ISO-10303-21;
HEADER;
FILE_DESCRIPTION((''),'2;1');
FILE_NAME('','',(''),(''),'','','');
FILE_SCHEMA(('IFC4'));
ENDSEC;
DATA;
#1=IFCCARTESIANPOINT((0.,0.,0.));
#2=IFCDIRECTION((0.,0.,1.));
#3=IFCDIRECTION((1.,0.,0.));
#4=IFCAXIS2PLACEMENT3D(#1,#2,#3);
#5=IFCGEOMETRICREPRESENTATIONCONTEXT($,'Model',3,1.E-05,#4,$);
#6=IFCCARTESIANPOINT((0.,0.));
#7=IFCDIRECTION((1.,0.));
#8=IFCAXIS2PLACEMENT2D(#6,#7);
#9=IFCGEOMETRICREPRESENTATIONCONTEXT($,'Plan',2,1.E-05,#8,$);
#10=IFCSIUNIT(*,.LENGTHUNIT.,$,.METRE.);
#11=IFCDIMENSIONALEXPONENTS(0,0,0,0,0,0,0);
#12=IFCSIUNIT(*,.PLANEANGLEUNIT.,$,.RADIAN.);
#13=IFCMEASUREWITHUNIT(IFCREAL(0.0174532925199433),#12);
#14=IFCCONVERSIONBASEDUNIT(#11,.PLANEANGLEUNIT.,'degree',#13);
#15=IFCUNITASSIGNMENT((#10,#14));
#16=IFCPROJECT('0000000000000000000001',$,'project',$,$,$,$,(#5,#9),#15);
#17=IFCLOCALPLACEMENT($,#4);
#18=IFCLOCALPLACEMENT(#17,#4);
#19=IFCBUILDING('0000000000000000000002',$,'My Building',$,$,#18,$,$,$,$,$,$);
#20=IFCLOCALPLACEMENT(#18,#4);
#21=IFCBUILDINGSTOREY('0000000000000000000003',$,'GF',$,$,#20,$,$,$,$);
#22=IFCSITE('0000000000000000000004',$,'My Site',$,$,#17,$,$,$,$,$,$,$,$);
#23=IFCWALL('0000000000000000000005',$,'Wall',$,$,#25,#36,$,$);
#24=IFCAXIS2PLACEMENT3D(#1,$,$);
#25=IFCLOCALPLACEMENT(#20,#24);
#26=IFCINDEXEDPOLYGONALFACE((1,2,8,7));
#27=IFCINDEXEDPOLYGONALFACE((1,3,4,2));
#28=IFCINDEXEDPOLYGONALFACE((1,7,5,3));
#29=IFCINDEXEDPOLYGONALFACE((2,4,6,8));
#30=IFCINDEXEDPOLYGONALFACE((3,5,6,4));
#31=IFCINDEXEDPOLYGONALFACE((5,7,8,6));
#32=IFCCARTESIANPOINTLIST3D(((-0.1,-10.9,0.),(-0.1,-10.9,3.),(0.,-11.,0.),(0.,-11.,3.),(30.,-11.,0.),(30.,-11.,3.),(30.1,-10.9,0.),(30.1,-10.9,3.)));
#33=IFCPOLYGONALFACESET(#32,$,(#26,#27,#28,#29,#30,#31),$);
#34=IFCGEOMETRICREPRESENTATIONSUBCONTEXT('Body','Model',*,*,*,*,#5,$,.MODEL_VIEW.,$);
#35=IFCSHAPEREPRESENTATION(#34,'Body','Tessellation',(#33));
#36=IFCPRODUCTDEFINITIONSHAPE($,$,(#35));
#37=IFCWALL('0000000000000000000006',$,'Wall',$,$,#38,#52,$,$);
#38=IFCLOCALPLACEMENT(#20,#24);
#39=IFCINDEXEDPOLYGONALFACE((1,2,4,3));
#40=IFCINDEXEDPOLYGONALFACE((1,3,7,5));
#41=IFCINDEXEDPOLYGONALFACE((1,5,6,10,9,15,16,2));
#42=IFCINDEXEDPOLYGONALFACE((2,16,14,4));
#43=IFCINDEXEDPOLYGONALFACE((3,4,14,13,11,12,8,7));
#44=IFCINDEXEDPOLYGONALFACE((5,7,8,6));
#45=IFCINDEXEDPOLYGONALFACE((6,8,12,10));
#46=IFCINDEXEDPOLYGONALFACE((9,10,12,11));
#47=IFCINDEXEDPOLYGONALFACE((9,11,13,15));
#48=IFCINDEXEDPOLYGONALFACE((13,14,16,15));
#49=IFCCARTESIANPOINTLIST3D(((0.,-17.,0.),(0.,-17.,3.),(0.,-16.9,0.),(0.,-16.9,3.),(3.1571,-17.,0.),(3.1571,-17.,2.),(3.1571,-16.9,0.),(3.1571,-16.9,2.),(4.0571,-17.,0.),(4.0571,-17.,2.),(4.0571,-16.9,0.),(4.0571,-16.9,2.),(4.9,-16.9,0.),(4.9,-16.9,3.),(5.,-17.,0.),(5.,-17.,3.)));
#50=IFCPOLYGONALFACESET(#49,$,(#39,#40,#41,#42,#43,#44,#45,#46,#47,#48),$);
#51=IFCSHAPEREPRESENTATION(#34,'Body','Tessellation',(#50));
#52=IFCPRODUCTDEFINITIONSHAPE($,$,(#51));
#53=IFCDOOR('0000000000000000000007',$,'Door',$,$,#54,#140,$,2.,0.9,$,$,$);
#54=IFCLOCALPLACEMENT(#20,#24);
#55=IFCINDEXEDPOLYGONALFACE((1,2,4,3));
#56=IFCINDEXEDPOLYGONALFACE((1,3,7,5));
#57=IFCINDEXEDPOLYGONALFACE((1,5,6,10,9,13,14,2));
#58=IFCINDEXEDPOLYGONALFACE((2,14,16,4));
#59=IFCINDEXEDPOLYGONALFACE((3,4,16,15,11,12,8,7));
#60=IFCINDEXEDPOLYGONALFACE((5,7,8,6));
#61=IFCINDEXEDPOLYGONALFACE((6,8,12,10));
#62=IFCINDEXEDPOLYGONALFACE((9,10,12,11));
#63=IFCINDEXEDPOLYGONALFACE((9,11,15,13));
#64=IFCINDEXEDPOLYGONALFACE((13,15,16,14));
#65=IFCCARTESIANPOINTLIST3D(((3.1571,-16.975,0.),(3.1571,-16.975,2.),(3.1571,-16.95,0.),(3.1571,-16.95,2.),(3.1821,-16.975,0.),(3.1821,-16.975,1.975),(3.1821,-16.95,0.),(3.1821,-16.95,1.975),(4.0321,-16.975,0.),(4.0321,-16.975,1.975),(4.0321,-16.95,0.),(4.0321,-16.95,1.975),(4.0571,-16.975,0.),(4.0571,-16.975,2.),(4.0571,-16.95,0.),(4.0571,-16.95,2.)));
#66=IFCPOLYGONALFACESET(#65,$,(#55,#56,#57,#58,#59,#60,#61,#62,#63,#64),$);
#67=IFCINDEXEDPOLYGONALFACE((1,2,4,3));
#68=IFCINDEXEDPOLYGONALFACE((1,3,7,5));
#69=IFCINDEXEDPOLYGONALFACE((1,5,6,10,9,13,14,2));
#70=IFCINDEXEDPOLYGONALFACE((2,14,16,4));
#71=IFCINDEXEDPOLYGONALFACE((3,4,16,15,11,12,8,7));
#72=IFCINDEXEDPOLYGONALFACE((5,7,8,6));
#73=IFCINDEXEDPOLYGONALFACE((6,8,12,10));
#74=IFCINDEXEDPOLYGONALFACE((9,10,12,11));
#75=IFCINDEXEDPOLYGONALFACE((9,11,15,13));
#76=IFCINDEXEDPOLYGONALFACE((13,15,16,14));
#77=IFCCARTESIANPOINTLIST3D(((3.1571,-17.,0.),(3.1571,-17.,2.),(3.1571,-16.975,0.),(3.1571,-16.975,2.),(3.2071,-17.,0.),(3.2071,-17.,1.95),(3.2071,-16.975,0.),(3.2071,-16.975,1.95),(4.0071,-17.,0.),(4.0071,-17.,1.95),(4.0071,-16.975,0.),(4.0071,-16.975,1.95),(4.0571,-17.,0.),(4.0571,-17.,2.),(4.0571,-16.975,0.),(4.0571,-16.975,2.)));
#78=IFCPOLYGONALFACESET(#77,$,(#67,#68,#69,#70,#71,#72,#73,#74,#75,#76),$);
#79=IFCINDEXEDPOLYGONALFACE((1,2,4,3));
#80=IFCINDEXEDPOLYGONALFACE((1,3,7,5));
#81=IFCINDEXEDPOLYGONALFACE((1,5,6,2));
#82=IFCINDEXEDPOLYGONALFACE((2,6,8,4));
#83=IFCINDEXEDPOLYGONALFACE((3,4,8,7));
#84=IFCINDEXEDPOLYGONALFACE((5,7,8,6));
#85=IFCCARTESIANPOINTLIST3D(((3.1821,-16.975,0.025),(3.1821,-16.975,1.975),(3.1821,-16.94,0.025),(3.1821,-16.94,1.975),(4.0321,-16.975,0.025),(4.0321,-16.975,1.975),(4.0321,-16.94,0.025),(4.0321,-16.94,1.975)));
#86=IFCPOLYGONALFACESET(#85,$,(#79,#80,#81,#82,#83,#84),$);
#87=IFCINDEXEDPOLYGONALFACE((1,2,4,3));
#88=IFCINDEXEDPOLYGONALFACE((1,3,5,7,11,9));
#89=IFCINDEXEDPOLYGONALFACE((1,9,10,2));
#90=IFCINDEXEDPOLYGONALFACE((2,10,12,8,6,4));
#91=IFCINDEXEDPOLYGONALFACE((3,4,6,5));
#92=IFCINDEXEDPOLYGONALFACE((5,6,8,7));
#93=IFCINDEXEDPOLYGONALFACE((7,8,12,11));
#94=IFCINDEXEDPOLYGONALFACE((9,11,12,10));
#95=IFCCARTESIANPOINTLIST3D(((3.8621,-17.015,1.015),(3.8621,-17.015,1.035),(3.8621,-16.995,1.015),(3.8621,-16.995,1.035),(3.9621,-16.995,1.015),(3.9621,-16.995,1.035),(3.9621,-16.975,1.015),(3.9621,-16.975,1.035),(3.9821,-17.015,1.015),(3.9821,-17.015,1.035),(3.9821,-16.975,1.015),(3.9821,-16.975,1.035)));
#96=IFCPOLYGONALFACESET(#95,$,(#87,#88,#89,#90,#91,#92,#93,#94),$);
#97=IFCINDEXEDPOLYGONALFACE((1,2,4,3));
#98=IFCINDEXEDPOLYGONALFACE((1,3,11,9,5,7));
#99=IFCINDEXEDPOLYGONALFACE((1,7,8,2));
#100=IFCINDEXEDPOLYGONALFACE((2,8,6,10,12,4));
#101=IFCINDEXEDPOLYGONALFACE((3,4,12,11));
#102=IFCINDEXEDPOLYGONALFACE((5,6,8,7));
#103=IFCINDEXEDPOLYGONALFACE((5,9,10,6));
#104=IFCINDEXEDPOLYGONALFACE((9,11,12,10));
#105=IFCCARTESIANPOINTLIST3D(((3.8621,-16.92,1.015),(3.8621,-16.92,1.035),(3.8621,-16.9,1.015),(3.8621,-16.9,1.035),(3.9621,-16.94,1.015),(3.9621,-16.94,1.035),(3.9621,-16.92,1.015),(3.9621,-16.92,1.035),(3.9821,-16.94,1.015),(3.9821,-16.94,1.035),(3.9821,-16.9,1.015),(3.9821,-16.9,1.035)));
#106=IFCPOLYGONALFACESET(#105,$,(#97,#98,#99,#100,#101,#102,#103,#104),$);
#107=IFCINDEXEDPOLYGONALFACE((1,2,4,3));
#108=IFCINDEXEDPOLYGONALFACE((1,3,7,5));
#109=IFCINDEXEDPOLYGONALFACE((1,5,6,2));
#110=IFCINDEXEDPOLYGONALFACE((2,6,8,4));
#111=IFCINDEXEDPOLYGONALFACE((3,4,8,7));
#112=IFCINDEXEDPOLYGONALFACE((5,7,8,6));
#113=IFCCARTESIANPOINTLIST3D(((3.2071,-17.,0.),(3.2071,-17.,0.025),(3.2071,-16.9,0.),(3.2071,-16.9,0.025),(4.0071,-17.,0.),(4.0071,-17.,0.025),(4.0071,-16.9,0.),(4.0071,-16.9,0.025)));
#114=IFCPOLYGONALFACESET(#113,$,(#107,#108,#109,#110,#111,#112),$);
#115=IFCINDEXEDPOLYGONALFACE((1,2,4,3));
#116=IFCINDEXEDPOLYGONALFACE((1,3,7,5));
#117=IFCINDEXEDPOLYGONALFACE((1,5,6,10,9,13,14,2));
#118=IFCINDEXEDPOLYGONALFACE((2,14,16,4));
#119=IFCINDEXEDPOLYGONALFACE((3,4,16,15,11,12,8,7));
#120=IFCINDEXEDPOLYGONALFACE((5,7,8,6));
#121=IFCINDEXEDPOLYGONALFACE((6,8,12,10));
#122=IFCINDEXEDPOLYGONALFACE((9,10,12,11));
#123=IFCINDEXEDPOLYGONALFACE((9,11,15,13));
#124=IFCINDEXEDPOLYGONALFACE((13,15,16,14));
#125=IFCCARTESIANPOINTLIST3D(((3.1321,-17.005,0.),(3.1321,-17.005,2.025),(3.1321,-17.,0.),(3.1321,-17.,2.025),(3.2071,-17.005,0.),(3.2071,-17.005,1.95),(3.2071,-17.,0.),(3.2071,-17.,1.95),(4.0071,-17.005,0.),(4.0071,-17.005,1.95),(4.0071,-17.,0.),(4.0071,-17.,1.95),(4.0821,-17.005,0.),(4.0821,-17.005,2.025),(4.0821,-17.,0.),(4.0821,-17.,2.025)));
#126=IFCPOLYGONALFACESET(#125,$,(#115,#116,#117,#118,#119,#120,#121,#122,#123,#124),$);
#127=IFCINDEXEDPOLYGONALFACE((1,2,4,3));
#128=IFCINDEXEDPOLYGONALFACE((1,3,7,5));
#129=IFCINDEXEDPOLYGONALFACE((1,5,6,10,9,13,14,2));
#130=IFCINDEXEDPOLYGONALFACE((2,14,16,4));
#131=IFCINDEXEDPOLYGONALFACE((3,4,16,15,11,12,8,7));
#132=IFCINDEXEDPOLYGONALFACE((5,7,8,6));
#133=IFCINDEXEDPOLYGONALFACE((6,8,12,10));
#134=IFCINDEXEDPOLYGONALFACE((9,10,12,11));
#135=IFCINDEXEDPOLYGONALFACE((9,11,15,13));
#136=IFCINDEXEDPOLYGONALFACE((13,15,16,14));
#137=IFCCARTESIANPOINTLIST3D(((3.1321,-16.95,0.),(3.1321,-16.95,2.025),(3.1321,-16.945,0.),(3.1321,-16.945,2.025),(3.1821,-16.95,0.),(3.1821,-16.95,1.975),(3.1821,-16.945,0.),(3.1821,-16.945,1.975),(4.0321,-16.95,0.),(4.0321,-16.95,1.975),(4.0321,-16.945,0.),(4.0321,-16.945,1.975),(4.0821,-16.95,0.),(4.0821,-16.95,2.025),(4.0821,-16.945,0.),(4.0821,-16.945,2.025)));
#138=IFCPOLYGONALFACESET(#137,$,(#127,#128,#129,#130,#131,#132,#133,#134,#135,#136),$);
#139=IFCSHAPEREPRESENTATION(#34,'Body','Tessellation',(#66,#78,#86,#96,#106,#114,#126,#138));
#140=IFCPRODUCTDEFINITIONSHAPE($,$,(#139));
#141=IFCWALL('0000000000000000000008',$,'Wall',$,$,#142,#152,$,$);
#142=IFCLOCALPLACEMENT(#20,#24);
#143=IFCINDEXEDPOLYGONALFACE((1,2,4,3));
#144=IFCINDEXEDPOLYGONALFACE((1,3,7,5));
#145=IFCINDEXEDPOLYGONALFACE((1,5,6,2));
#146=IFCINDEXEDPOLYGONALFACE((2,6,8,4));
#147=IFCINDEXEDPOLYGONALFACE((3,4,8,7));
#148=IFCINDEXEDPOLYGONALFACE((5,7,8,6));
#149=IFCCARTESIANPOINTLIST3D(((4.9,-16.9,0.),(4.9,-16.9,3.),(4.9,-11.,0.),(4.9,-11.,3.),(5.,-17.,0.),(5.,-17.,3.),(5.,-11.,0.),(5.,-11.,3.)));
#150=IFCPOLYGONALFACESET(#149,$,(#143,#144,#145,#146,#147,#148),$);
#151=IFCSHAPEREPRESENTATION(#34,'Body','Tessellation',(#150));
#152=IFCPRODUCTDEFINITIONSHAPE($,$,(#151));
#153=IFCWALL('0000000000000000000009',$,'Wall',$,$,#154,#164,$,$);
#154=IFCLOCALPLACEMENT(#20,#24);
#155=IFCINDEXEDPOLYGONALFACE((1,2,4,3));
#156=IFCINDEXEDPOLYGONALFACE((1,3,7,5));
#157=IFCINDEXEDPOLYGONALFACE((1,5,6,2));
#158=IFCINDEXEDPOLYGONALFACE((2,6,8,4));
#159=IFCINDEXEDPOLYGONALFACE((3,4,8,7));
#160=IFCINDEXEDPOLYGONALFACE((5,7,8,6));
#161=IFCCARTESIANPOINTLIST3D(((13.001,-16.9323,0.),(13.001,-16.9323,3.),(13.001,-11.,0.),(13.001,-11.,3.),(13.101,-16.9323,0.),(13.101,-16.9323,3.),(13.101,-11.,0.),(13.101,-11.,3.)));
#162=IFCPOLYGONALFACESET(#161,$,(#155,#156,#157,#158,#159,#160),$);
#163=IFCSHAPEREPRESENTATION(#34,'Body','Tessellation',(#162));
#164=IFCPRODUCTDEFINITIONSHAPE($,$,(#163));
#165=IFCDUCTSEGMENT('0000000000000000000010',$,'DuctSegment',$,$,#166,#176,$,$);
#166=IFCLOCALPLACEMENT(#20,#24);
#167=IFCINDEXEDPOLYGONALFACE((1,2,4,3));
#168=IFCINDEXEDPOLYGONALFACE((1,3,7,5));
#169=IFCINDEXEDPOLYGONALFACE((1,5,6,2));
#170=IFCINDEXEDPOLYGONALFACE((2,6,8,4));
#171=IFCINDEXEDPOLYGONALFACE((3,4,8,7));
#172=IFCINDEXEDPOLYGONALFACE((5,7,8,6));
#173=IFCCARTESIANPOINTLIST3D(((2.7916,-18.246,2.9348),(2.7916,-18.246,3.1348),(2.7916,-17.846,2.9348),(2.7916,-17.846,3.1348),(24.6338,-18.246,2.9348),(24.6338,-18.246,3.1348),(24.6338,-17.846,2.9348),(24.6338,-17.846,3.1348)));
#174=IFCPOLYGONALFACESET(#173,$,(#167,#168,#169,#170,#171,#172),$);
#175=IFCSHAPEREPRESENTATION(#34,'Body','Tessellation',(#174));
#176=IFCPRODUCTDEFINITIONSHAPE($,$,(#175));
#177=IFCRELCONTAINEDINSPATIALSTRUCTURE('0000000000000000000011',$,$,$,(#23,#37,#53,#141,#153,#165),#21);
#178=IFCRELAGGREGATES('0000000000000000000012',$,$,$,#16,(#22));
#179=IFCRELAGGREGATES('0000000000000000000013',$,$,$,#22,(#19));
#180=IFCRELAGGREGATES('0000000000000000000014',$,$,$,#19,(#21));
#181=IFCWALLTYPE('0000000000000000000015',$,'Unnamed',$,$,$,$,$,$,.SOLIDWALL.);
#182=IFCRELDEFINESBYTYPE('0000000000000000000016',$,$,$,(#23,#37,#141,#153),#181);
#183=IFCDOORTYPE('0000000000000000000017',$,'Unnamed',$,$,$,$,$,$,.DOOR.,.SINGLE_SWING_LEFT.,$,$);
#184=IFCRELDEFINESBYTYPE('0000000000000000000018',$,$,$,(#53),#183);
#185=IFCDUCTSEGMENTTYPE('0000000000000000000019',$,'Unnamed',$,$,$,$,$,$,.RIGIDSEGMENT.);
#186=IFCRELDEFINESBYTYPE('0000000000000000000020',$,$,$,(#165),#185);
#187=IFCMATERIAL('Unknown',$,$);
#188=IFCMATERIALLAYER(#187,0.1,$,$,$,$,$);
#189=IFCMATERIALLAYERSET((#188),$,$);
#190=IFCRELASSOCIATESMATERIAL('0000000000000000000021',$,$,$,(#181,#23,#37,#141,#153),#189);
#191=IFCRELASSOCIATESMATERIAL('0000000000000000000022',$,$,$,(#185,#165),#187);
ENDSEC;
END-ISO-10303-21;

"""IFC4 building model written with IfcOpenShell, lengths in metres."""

from ifc_helpers import new_model, entity, si_unit, converted_unit, frame, origin_with_axes, origin_2d_with_axis, place, context, subcontext, project, spatial, line, indexed_curve, rectangle, outline, extrude, shape, source, transform, mapped, material, layer, layer_set, layer_usage, material_profile, profile_set, profile_usage, type_object, type_shapes, element, fill, save


model = new_model("IFC4")

# Units and contexts
model_context = context("Model", 3, precision=1e-05, world=origin_with_axes())
plan_context = context("Plan", 2, precision=1e-05, world=origin_2d_with_axis())
body_context_1 = subcontext(model_context, "Body", "Model", "MODEL_VIEW")
body_context_2 = subcontext(plan_context, "Body", "Plan", "PLAN_VIEW")
ifc_project = project(units=[si_unit("LENGTHUNIT", "METRE"), converted_unit("PLANEANGLEUNIT", "degree", entity("IfcReal", 0.0174532925199433), si_unit("PLANEANGLEUNIT", "RADIAN"), dimensions=[0, 0, 0, 0, 0, 0, 0])], contexts=[model_context, plan_context])

# Site, building, storey
site_placement = place(None, origin_with_axes())
site = spatial("IfcSite", under=ifc_project, at=site_placement, Name="My Site")
building_placement = place(site_placement, origin_with_axes())
building = spatial("IfcBuilding", under=site, at=building_placement, Name="My Building")
storey_placement = place(building_placement, origin_with_axes())
storey = spatial("IfcBuildingStorey", under=building, at=storey_placement, Name="GF")

# Wall
ifc_material = material(Name="Unknown")
ifc_layer = layer(ifc_material, 0.1)
ifc_layer_set = layer_set([ifc_layer])
ifc_layer_usage_1 = layer_usage(ifc_layer_set, "AXIS2", "POSITIVE", 0.0)
wall_type = type_object("IfcWallType", Name="Unnamed", PredefinedType="SOLIDWALL", material=ifc_layer_set)
wall_1_placement = place(storey_placement, frame((0.0, -11.0, 0.0), z_axis=(0.0, 0.0, 1.0), x_axis=(1.0, 0.0, 0.0)))
element("IfcWall", 1, at=wall_1_placement, inside=storey, type_object=wall_type, material=ifc_layer_usage_1, Name="Wall", context=body_context_1, shape_type="SweptSolid", body=[
    extrude(outline(indexed_curve([(0.0, 0.0), (-0.1, 0.1), (30.1, 0.1), (30.0, 0.0)], segments=[line(1, 2, 3, 4, 1)])), origin_with_axes(), (0.0, 0.0, 1.0), 3.0),
])

# Wall, opening, door
ifc_layer_usage_2 = layer_usage(ifc_layer_set, "AXIS2", "POSITIVE", 0.0)
wall_2_placement = place(storey_placement, frame((0.0, -17.0, 0.0), z_axis=(0.0, 0.0, 1.0), x_axis=(1.0, 0.0, 0.0)))
wall_2 = element("IfcWall", 2, at=wall_2_placement, inside=storey, type_object=wall_type, material=ifc_layer_usage_2, Name="Wall", context=body_context_1, shape_type="SweptSolid", body=[
    extrude(outline(indexed_curve([(0.0, 0.0), (0.0, 0.1), (4.9, 0.1), (5.0, 0.0)], segments=[line(1, 2, 3, 4, 1)])), origin_with_axes(), (0.0, 0.0, 1.0), 3.0),
])
shared_shape_1 = source(origin_with_axes(), body_context_1, "Body", "SweptSolid", [
    extrude(outline(indexed_curve([(0.0, 0.0), (0.9, 0.0), (0.9, 2.0), (0.0, 2.0)], segments=[line(1, 2, 3, 4, 1)])), frame((0.0, -0.6, 0.0), z_axis=(0.0, -1.0, 0.0), x_axis=(1.0, 0.0, 0.0)), (0.0, 0.0, -1.0), 1.2),
])
opening_1_placement = place(wall_2_placement, frame((3.1571, 0.0, 0.0), z_axis=(0.0, 0.0, 1.0), x_axis=(1.0, 0.0, 0.0)))
opening_1 = element("IfcOpeningElement", 3, at=opening_1_placement, cuts=wall_2, PredefinedType="OPENING", context=body_context_1, shape_type="MappedRepresentation", body=[
    mapped(shared_shape_1, transform((0.0, 0.0, 0.0), x_axis=(1.0, 0.0, 0.0), y_axis=(0.0, 1.0, 0.0), z_axis=(0.0, 0.0, 1.0), scale=1.0)),
])
door_type = type_object("IfcDoorType", Name="Unnamed", OperationType="SINGLE_SWING_LEFT", PredefinedType="DOOR")
shared_shape_2 = source(origin_with_axes(), body_context_1, "Body", "SweptSolid", [
    extrude(outline(indexed_curve([(0.0, 0.0), (0.0, 2.0), (0.9, 2.0), (0.9, 0.0), (0.875, 0.0), (0.875, 1.975), (0.025, 1.975), (0.025, 0.0)], segments=[line(1, 2, 3, 4, 5, 6, 7, 8, 1)])), frame((0.0, 0.025, 0.0), z_axis=(0.0, -1.0, 0.0), x_axis=(1.0, 0.0, 0.0)), (0.0, 0.0, -1.0), 0.025),
    extrude(outline(indexed_curve([(0.0, 0.0), (0.0, 2.0), (0.9, 2.0), (0.9, 0.0), (0.85, 0.0), (0.85, 1.95), (0.05, 1.95), (0.05, 0.0)], segments=[line(1, 2, 3, 4, 5, 6, 7, 8, 1)])), frame((0.0, 0.0, 0.0), z_axis=(0.0, -1.0, 0.0), x_axis=(1.0, 0.0, 0.0)), (0.0, 0.0, -1.0), 0.025),
    extrude(outline(indexed_curve([(0.0, 0.0), (0.85, 0.0), (0.85, 0.035), (0.0, 0.035)], segments=[line(1, 2, 3, 4, 1)])), frame((0.025, 0.025, 0.025), z_axis=(0.0, 0.0, 1.0), x_axis=(1.0, 0.0, 0.0)), (0.0, 0.0, 1.0), 1.95),
    extrude(outline(indexed_curve([(0.0, 0.0), (0.0, -0.04), (-0.12, -0.04), (-0.12, -0.02), (-0.02, -0.02), (-0.02, 0.0)], segments=[line(1, 2, 3, 4, 5, 6, 1)])), frame((0.825, 0.025, 1.015), z_axis=(0.0, 0.0, 1.0), x_axis=(1.0, 0.0, 0.0)), (0.0, 0.0, 1.0), 0.02),
    extrude(outline(indexed_curve([(0.0, 0.0), (0.0, 0.04), (-0.12, 0.04), (-0.12, 0.02), (-0.02, 0.02), (-0.02, 0.0)], segments=[line(1, 2, 3, 4, 5, 6, 1)])), frame((0.825, 0.06, 1.015), z_axis=(0.0, 0.0, 1.0), x_axis=(1.0, 0.0, 0.0)), (0.0, 0.0, 1.0), 0.02),
    extrude(outline(indexed_curve([(0.0, 0.0), (0.8, 0.0), (0.8, 0.1), (0.0, 0.1)], segments=[line(1, 2, 3, 4, 1)])), frame((0.05, 0.0, 0.0), z_axis=(0.0, 0.0, 1.0), x_axis=(1.0, 0.0, 0.0)), (0.0, 0.0, 1.0), 0.025),
    extrude(outline(indexed_curve([(0.0, 0.0), (0.0, 2.025), (0.95, 2.025), (0.95, 0.0), (0.875, 0.0), (0.875, 1.95), (0.075, 1.95), (0.075, 0.0)], segments=[line(1, 2, 3, 4, 5, 6, 7, 8, 1)])), frame((-0.025, -0.005, 0.0), z_axis=(0.0, -1.0, 0.0), x_axis=(1.0, 0.0, 0.0)), (0.0, 0.0, -1.0), 0.005),
    extrude(outline(indexed_curve([(0.0, 0.0), (0.0, 2.025), (0.95, 2.025), (0.95, 0.0), (0.9, 0.0), (0.9, 1.975), (0.05, 1.975), (0.05, 0.0)], segments=[line(1, 2, 3, 4, 5, 6, 7, 8, 1)])), frame((-0.025, 0.05, 0.0), z_axis=(0.0, -1.0, 0.0), x_axis=(1.0, 0.0, 0.0)), (0.0, 0.0, -1.0), 0.005),
])
shared_shape_3 = source(origin_with_axes(), body_context_2, "Body", "Curve2D", [
    entity("IfcIndexedPolyCurve", entity("IfcCartesianPointList2D", [[0.0, 0.0], [0.0, 0.05], [0.025, 0.05], [0.025, 0.025], [0.05, 0.025], [0.05, 0.0]]), [entity("IfcLineIndex", [1, 2, 3, 4, 5, 6, 1])]),
    entity("IfcIndexedPolyCurve", entity("IfcCartesianPointList2D", [[0.9, 0.0], [0.9, 0.05], [0.875, 0.05], [0.875, 0.025], [0.85, 0.025], [0.85, 0.0]]), [entity("IfcLineIndex", [1, 2, 3, 4, 5, 6, 1])]),
    entity("IfcTrimmedCurve", entity("IfcEllipse", entity("IfcAxis2Placement2D", entity("IfcCartesianPoint", [0.06, 0.05]), entity("IfcDirection", [1.0, 0.0])), 0.815, 0.85), [entity("IfcCartesianPoint", [0.875, 0.05])], [entity("IfcCartesianPoint", [0.06, 0.9])], True, "CARTESIAN"),
    entity("IfcIndexedPolyCurve", entity("IfcCartesianPointList2D", [[0.025, 0.05], [0.06, 0.05], [0.06, 0.9], [0.025, 0.9]]), [entity("IfcLineIndex", [1, 2, 3, 4, 1])]),
])
type_shapes(door_type, [shared_shape_2, shared_shape_3])
door_1_placement = place(opening_1_placement, origin_with_axes())
door_1 = element("IfcDoor", 4, at=door_1_placement, inside=storey, type_object=door_type, Name="Door", OverallHeight=2.0, OverallWidth=0.9, shapes=[
    shape(body_context_1, "Body", "MappedRepresentation", [mapped(shared_shape_2, transform((0.0, 0.0, 0.0), x_axis=(1.0, 0.0, 0.0), y_axis=(0.0, 1.0, 0.0), z_axis=(0.0, 0.0, 1.0), scale=1.0))]),
    shape(body_context_2, "Body", "MappedRepresentation", [mapped(shared_shape_3, transform((0.0, 0.0, 0.0), x_axis=(1.0, 0.0, 0.0), y_axis=(0.0, 1.0, 0.0), z_axis=(0.0, 0.0, 1.0), scale=1.0))]),
])
fill(opening_1, door_1)

# Wall
ifc_layer_usage_3 = layer_usage(ifc_layer_set, "AXIS2", "POSITIVE", 0.0)
wall_3_placement = place(storey_placement, frame((5.0, -17.0, 0.0), z_axis=(0.0, 0.0, 1.0), x_axis=(0.0, 1.0, 0.0)))
element("IfcWall", 5, at=wall_3_placement, inside=storey, type_object=wall_type, material=ifc_layer_usage_3, Name="Wall", context=body_context_1, shape_type="SweptSolid", body=[
    extrude(outline(indexed_curve([(0.0, 0.0), (0.1, 0.1), (6.0, 0.1), (6.0, 0.0)], segments=[line(1, 2, 3, 4, 1)])), origin_with_axes(), (0.0, 0.0, 1.0), 3.0),
])

# Wall
ifc_layer_usage_4 = layer_usage(ifc_layer_set, "AXIS2", "POSITIVE", 0.0)
wall_4_placement = place(storey_placement, frame((13.101, -16.9323, 0.0), z_axis=(0.0, 0.0, 1.0), x_axis=(0.0, 1.0, 0.0)))
element("IfcWall", 6, at=wall_4_placement, inside=storey, type_object=wall_type, material=ifc_layer_usage_4, Name="Wall", context=body_context_1, shape_type="SweptSolid", body=[
    extrude(outline(indexed_curve([(0.0, 0.0), (0.0, 0.1), (5.9323, 0.1), (5.9323, 0.0)], segments=[line(1, 2, 3, 4, 1)])), origin_with_axes(), (0.0, 0.0, 1.0), 3.0),
])

# Duct segment
ifc_material_profile_1 = material_profile(ifc_material, rectangle(XDim=0.4, YDim=0.2))
ifc_profile_set_1 = profile_set([ifc_material_profile_1])
ifc_profile_usage_1 = profile_usage(ifc_profile_set_1, cardinal=5)
duct_segment_type = type_object("IfcDuctSegmentType", Name="Unnamed", PredefinedType="RIGIDSEGMENT", material=ifc_profile_set_1)
duct_segment_1_placement = place(storey_placement, frame((2.7916, -18.046, 3.0348), z_axis=(1.0, 0.0, 0.0), x_axis=(0.0, 1.0, 0.0)))
element("IfcDuctSegment", 7, at=duct_segment_1_placement, inside=storey, type_object=duct_segment_type, material=ifc_profile_usage_1, Name="DuctSegment", context=body_context_1, shape_type="SweptSolid", body=[
    extrude(rectangle(XDim=0.4, YDim=0.2), origin_with_axes(), (0.0, 0.0, 1.0), 21.8422),
])

save(model, "model.ifc")
